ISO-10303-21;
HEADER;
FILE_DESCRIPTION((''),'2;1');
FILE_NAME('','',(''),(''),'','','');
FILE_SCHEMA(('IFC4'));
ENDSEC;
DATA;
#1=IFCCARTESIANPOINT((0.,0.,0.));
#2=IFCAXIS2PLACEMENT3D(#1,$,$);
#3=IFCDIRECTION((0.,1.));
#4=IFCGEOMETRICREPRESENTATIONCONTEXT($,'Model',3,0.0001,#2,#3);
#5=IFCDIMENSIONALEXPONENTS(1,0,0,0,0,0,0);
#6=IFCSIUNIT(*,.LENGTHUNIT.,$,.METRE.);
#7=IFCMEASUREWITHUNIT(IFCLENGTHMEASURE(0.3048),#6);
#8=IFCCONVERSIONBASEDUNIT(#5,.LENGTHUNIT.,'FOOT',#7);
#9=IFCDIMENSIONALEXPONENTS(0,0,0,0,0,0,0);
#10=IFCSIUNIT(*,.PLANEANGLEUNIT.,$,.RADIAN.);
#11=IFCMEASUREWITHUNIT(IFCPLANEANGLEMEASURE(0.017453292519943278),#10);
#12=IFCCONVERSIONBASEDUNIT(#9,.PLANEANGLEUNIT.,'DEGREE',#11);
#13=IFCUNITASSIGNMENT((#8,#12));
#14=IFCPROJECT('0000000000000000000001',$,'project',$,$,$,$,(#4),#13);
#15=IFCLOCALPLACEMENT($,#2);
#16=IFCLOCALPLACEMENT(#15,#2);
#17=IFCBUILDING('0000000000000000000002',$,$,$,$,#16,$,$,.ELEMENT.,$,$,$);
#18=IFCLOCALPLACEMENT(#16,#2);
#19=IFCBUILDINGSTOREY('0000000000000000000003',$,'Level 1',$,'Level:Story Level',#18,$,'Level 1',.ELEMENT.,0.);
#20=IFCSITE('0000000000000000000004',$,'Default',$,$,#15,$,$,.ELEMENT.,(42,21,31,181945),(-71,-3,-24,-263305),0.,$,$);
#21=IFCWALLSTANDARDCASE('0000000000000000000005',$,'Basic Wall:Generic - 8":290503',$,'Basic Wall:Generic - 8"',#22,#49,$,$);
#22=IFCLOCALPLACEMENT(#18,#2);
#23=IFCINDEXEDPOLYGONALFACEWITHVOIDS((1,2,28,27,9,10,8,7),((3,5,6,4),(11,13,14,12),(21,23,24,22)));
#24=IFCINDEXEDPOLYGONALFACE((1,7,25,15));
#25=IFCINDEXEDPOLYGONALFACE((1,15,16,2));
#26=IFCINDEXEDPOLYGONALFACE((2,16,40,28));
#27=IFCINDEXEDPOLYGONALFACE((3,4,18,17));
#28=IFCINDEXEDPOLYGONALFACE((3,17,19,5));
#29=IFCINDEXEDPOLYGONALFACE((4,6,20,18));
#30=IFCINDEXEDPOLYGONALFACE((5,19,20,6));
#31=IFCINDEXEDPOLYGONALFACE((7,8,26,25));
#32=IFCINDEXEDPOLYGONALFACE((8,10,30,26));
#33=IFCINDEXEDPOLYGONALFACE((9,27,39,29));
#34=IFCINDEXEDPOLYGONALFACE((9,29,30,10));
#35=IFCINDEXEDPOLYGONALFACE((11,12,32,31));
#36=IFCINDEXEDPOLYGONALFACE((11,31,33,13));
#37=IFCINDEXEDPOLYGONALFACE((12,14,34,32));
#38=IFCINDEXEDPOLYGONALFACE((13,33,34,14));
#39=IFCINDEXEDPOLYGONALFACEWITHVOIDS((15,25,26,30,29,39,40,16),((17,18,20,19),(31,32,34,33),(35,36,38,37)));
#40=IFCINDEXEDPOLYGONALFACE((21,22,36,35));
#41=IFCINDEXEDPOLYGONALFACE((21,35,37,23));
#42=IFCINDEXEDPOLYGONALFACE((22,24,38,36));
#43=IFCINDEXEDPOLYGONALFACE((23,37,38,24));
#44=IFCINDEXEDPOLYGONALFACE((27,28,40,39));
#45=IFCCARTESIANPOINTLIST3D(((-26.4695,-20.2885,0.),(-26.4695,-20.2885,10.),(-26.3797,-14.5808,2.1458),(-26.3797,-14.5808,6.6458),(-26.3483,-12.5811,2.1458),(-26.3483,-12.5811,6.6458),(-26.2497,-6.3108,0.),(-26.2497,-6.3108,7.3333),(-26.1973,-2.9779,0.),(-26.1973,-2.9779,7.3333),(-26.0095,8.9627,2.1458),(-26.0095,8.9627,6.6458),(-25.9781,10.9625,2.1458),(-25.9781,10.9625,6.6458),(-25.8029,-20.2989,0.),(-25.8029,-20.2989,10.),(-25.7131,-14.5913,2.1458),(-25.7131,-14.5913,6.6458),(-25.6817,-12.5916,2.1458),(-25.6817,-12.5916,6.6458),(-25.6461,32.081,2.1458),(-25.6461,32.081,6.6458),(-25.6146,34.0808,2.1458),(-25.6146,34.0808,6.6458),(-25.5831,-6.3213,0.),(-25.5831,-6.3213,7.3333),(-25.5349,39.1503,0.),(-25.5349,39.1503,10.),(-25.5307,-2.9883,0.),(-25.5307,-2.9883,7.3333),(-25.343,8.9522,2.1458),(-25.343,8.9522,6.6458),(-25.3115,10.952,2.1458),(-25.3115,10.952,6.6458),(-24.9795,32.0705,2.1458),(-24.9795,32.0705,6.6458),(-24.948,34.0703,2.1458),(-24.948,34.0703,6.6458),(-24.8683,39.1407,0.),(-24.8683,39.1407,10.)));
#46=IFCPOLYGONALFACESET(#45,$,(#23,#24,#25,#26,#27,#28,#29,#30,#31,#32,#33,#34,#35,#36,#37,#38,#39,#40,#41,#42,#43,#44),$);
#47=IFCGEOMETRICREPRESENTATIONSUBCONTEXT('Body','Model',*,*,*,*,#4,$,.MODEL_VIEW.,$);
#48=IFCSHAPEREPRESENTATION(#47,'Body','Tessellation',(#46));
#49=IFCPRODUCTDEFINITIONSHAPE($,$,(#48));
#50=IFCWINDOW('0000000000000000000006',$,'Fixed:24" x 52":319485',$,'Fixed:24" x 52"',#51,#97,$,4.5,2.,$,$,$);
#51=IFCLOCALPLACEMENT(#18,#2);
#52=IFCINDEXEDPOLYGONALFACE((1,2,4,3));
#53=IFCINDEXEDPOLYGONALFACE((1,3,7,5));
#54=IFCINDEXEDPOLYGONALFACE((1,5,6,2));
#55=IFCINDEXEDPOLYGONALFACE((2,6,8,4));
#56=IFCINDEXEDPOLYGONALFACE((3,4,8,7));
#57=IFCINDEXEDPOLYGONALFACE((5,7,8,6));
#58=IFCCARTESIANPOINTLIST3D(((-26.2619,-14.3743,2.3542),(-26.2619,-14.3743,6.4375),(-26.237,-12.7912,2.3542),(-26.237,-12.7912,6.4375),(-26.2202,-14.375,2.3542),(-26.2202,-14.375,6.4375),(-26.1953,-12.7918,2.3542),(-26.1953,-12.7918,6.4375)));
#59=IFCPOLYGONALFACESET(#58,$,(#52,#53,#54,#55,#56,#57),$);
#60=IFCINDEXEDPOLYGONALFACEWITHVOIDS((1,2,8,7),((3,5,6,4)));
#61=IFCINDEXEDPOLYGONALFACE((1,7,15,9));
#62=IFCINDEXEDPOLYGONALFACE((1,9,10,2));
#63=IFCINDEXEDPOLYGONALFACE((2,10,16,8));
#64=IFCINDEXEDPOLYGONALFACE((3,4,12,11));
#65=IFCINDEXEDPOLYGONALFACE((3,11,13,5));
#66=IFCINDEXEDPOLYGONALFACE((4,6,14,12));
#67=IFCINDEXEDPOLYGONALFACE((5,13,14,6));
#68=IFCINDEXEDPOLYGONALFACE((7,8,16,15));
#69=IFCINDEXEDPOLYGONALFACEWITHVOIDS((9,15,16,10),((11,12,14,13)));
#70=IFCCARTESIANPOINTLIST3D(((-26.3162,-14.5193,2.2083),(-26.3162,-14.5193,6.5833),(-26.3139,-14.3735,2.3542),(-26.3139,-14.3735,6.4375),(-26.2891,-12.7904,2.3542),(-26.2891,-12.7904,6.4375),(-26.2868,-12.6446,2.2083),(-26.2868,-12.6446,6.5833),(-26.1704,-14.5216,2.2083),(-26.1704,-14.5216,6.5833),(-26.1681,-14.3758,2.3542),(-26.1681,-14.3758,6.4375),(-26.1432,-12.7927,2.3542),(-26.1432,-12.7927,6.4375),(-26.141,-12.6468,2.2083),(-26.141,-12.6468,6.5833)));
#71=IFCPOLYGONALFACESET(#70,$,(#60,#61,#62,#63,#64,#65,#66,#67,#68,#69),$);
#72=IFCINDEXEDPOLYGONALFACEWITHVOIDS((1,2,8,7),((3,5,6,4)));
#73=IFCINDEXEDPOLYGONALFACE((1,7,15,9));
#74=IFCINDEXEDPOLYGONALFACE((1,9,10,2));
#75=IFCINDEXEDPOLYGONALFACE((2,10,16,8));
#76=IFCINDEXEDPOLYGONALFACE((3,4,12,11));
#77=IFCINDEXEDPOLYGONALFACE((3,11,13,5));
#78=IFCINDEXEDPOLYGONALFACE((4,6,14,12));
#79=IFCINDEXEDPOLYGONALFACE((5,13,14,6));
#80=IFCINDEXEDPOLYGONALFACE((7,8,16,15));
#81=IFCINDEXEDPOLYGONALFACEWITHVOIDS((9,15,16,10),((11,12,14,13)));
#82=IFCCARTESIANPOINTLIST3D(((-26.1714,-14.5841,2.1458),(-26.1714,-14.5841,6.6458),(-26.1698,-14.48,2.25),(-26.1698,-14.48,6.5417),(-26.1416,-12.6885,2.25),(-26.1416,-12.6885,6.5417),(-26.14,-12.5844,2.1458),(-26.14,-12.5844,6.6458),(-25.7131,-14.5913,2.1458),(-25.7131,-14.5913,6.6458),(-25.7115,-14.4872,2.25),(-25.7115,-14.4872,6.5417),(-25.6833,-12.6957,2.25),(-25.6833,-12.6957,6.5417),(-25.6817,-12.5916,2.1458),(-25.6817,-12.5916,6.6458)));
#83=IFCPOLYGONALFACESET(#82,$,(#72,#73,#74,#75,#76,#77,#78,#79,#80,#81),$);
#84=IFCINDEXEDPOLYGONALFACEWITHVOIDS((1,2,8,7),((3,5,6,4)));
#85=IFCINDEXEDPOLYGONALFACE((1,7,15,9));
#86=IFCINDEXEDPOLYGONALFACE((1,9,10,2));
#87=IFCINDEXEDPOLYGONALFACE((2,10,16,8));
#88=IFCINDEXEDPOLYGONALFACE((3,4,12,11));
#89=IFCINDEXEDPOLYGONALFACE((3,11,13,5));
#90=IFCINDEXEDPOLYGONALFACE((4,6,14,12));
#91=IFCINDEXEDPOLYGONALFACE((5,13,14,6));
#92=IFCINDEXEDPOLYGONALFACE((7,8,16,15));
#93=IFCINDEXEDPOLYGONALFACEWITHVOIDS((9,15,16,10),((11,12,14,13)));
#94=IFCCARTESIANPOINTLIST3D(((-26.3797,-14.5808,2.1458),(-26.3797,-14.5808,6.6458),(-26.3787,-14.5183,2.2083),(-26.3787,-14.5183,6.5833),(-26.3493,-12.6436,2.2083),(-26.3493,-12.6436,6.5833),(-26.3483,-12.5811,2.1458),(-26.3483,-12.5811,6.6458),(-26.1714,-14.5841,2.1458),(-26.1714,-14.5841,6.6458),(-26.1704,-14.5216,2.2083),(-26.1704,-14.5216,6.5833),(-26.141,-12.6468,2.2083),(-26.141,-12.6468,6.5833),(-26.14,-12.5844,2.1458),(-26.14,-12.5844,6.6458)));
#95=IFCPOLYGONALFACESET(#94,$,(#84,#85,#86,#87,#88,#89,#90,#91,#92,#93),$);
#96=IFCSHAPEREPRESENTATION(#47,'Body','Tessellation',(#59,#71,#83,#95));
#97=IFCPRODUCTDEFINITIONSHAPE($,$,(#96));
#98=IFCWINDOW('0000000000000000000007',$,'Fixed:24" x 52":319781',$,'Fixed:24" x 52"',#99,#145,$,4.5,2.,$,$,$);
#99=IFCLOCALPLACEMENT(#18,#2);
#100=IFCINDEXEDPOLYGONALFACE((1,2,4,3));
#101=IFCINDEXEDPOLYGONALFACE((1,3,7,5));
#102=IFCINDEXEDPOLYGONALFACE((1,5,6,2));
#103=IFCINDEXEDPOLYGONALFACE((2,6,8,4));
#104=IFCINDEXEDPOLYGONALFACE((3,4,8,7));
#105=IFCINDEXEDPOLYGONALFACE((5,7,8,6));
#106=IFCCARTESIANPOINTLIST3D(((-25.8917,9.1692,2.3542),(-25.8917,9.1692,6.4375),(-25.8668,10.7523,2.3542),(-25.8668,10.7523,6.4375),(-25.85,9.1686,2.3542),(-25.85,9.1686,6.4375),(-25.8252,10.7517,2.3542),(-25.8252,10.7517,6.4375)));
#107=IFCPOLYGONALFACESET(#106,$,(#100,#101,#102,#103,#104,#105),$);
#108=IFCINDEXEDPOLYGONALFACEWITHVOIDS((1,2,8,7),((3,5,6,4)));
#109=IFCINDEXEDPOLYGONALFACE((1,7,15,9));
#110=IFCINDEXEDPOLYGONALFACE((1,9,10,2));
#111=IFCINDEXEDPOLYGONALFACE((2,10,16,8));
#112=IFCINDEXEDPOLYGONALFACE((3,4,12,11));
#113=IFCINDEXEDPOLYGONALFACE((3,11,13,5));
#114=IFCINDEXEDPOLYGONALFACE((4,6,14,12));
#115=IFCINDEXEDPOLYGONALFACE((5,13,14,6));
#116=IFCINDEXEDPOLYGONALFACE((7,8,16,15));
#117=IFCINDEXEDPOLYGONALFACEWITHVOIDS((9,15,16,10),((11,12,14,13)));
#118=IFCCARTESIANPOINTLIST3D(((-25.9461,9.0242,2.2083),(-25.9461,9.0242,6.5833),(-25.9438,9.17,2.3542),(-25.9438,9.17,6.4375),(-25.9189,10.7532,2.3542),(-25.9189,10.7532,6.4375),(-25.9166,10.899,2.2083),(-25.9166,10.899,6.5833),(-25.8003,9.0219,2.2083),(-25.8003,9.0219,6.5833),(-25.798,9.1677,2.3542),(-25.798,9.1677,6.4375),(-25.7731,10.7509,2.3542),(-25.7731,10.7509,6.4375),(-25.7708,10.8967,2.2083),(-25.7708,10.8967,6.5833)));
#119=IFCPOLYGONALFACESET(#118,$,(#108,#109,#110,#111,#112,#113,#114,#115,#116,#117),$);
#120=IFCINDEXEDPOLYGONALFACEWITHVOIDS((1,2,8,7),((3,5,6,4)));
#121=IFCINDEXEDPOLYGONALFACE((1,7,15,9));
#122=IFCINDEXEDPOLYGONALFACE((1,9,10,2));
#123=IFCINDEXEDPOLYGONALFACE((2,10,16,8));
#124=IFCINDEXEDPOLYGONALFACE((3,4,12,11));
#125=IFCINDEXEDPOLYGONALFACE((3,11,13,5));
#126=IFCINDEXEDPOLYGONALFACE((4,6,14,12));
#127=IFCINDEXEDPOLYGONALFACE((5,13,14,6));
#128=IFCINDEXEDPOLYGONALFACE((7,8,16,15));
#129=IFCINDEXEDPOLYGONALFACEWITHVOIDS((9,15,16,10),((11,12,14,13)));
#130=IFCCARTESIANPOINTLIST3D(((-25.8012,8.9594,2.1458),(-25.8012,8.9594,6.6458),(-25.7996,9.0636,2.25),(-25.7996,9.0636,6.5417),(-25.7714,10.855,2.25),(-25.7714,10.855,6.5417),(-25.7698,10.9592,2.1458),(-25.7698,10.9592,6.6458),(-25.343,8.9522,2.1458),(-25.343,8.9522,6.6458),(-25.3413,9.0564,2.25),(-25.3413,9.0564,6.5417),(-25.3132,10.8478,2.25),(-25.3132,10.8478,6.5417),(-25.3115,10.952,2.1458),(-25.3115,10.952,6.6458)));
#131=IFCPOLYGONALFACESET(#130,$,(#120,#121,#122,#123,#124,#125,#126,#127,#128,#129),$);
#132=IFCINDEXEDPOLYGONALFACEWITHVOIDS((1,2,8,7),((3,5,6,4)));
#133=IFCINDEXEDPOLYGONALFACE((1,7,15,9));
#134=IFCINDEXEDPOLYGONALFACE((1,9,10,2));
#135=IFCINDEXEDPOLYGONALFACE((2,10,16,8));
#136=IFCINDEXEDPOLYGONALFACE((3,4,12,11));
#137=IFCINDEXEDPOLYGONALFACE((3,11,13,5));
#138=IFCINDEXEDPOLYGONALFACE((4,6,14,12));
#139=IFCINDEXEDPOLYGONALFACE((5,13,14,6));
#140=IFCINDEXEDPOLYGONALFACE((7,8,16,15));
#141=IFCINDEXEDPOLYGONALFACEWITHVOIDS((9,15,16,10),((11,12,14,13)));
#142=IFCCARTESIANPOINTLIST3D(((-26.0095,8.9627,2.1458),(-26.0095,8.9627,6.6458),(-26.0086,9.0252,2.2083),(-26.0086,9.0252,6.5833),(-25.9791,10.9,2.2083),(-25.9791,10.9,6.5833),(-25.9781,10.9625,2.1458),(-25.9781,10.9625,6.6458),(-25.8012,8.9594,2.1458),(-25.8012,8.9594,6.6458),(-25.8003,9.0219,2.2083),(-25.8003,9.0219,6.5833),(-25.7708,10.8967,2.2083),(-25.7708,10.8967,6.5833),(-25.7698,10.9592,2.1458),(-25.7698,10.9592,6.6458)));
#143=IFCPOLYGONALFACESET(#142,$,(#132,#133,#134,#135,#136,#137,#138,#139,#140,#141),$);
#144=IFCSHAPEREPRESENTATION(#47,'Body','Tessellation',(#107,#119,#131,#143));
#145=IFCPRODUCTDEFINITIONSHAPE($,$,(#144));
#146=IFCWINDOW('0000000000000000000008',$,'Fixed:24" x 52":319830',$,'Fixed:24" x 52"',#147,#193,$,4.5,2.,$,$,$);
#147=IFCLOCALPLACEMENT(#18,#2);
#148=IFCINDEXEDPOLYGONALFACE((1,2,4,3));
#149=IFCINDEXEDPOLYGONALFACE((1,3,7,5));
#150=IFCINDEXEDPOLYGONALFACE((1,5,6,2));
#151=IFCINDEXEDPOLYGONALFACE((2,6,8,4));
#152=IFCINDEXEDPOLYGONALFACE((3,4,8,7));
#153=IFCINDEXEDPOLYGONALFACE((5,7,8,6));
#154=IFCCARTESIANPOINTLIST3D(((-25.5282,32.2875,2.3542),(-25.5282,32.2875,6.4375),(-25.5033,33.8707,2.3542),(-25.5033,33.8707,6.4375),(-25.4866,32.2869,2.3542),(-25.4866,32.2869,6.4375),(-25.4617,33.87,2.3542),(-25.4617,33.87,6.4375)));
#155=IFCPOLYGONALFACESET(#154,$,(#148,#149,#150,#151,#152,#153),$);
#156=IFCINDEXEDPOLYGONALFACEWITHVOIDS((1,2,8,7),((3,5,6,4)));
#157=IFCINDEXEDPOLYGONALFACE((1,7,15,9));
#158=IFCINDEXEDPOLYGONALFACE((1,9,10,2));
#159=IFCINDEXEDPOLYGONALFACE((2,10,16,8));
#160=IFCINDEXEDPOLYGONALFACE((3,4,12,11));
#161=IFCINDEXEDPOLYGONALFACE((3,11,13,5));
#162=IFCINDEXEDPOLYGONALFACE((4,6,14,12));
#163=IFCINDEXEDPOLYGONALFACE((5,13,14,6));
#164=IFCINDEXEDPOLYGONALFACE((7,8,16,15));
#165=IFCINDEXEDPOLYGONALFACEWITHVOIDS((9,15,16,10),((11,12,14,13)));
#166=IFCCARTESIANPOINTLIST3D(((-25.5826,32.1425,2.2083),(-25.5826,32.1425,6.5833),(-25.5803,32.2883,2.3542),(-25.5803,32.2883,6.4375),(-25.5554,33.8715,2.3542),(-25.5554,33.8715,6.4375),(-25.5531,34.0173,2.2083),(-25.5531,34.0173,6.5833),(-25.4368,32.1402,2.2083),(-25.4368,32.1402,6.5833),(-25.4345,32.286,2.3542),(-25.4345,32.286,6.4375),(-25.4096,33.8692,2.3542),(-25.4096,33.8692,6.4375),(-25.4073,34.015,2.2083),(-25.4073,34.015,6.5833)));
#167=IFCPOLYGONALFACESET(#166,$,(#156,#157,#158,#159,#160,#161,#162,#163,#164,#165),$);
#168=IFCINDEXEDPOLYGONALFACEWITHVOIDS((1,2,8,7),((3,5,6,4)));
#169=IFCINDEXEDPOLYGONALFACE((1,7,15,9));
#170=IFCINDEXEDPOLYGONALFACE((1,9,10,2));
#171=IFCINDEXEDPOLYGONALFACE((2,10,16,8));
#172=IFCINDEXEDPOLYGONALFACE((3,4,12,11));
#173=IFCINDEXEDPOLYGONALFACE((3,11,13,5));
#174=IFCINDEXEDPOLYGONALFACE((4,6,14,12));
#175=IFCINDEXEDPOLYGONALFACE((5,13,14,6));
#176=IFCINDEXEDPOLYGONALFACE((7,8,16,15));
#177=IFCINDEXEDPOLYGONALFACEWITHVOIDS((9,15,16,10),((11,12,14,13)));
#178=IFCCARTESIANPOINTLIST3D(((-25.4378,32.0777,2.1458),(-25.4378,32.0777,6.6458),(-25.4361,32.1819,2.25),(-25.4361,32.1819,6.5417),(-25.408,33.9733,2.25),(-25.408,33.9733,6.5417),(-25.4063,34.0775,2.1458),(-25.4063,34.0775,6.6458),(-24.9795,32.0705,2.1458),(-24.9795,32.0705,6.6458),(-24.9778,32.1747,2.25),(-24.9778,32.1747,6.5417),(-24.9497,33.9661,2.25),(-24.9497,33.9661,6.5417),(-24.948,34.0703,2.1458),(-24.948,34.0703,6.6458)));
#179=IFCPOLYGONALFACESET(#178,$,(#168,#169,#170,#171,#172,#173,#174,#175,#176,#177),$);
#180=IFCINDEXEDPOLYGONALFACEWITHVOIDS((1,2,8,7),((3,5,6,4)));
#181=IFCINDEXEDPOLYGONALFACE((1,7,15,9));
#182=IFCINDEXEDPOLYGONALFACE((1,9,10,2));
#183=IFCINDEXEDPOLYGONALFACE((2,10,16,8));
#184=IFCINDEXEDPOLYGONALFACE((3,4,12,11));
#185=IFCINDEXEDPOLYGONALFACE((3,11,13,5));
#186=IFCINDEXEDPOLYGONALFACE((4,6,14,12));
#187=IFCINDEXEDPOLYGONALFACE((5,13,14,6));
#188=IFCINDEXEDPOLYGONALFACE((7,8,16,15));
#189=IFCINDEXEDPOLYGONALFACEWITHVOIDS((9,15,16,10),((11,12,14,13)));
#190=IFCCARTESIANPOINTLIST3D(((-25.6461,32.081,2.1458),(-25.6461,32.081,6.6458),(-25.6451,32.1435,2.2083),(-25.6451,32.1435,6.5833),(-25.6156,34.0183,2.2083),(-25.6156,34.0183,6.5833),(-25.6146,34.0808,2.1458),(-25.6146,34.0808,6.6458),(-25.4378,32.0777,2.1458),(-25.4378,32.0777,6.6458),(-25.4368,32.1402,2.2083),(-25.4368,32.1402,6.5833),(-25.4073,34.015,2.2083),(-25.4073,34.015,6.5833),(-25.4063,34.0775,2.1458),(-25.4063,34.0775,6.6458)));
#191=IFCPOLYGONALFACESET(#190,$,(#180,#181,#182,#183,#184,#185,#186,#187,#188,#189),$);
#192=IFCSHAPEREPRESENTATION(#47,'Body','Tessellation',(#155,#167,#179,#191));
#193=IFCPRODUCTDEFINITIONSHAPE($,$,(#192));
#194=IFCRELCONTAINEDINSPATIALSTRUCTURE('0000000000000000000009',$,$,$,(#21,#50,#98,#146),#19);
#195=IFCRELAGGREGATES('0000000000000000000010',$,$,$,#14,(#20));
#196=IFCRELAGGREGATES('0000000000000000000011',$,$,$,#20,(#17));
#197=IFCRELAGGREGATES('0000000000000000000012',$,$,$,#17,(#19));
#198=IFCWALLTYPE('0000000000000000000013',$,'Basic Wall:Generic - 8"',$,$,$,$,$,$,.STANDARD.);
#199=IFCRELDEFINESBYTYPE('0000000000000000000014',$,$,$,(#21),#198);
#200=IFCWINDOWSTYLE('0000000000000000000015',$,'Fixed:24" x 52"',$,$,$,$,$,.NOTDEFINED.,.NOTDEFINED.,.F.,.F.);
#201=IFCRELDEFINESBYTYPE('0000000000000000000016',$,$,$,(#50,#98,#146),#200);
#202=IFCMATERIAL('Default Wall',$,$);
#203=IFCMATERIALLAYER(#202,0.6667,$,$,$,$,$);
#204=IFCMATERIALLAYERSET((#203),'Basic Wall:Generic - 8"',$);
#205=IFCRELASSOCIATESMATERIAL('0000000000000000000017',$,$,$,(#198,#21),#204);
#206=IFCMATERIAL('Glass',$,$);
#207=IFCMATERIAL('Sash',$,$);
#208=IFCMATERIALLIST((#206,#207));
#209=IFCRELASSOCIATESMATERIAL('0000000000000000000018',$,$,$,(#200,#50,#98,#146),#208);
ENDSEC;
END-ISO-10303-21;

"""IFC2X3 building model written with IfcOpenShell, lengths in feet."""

from ifc_helpers import new_model, entity, si_unit, converted_unit, direction, frame, frame_2d, origin, place, context, subcontext, project, spatial, polyline, rectangle, outline, extrude, source, transform, mapped, material, material_list, layer, layer_set, layer_usage, type_object, type_shapes, element, fill, save


model = new_model("IFC2X3")

# Units and contexts
model_context = context("Model", 3, precision=0.0001, world=origin(), true_north=direction((0.0, 1.0)))
body_context = subcontext(model_context, "Body", "Model", "MODEL_VIEW")
ifc_project = project(units=[converted_unit("LENGTHUNIT", "FOOT", entity("IfcLengthMeasure", 0.3048), si_unit("LENGTHUNIT", "METRE"), dimensions=[1, 0, 0, 0, 0, 0, 0]), converted_unit("PLANEANGLEUNIT", "DEGREE", entity("IfcPlaneAngleMeasure", 0.017453292519943278), si_unit("PLANEANGLEUNIT", "RADIAN"), dimensions=[0, 0, 0, 0, 0, 0, 0])], contexts=[model_context])

# Site, building, storey
site_placement = place(None, origin())
site = spatial("IfcSite", under=ifc_project, at=site_placement, Name="Default", CompositionType="ELEMENT", RefLatitude=(42, 21, 31, 181945), RefLongitude=(-71, -3, -24, -263305), RefElevation=0.0)
building_placement = place(site_placement, origin())
building = spatial("IfcBuilding", under=site, at=building_placement, CompositionType="ELEMENT")
storey_placement = place(building_placement, origin())
storey = spatial("IfcBuildingStorey", under=building, at=storey_placement, Name="Level 1", ObjectType="Level:Story Level", LongName="Level 1", CompositionType="ELEMENT", Elevation=0.0)

# Wall, openings, windows
ifc_material_1 = material(Name="Default Wall")
ifc_layer_1 = layer(ifc_material_1, 0.6667)
ifc_layer_set_1 = layer_set([ifc_layer_1], Name="Basic Wall:Generic - 8\"")
ifc_layer_usage_1 = layer_usage(ifc_layer_set_1, "AXIS2", "NEGATIVE", 0.3333)
wall_type_1 = type_object("IfcWallType", Name="Basic Wall:Generic - 8\"", PredefinedType="STANDARD", material=ifc_layer_set_1)
wall_1_placement = place(storey_placement, frame((-25.2016, 39.146, 0.0), z_axis=(0.0, 0.0, 1.0), x_axis=(-0.015721, -0.999876, 0.0)))
wall_1 = element("IfcWallStandardCase", 1, at=wall_1_placement, inside=storey, type_object=wall_type_1, material=ifc_layer_usage_1, Name="Basic Wall:Generic - 8\":290503", ObjectType="Basic Wall:Generic - 8\"", context=body_context, shape_type="SweptSolid", body=[
    extrude(outline(polyline([(0.001, -0.3333), (59.447, -0.3333), (59.447, 0.3333), (58.7804, 0.3333), (0.0, 0.3333), (0.001, -0.3333)])), origin(), (0.0, 0.0, 1.0), 10.0),
])
opening_1_placement = place(wall_1_placement, frame((45.4676, 0.3333, 0.0)))
element("IfcOpeningElement", 2, at=opening_1_placement, cuts=wall_1, ObjectType="Opening", context=body_context, shape_type="SweptSolid", body=[
    extrude(rectangle(XDim=7.3333, YDim=3.3333, at=frame_2d((3.6667, 1.6667), x_axis=(1.0, 0.0))), frame((0.0, 0.0, 0.0), z_axis=(0.0, -1.0, 0.0), x_axis=(0.0, 0.0, 1.0)), (0.0, 0.0, 1.0), 0.6667),
])
opening_2_placement = place(wall_1_placement, frame((53.7387, 0.3333, 2.1458)))
opening_2 = element("IfcOpeningElement", 3, at=opening_2_placement, cuts=wall_1, ObjectType="Opening", context=body_context, shape_type="SweptSolid", body=[
    extrude(rectangle(XDim=4.5, YDim=2.0, at=frame_2d((2.25, 1.0), x_axis=(-1.0, 0.0))), frame((0.0, 0.0, 0.0), z_axis=(0.0, -1.0, 0.0), x_axis=(0.0, 0.0, 1.0)), (0.0, 0.0, 1.0), 0.6667),
])
opening_3_placement = place(wall_1_placement, frame((30.1922, 0.3333, 2.1458)))
opening_3 = element("IfcOpeningElement", 4, at=opening_3_placement, cuts=wall_1, ObjectType="Opening", context=body_context, shape_type="SweptSolid", body=[
    extrude(rectangle(XDim=4.5, YDim=2.0, at=frame_2d((2.25, 1.0), x_axis=(-1.0, 0.0))), frame((0.0, 0.0, 0.0), z_axis=(0.0, -1.0, 0.0), x_axis=(0.0, 0.0, 1.0)), (0.0, 0.0, 1.0), 0.6667),
])
opening_4_placement = place(wall_1_placement, frame((7.0711, 0.3333, 2.1458)))
opening_4 = element("IfcOpeningElement", 5, at=opening_4_placement, cuts=wall_1, ObjectType="Opening", context=body_context, shape_type="SweptSolid", body=[
    extrude(rectangle(XDim=4.5, YDim=2.0, at=frame_2d((2.25, 1.0), x_axis=(-1.0, 0.0))), frame((0.0, 0.0, 0.0), z_axis=(0.0, -1.0, 0.0), x_axis=(0.0, 0.0, 1.0)), (0.0, 0.0, 1.0), 0.6667),
])
ifc_material_2 = material(Name="Glass")
ifc_material_3 = material(Name="Sash")
ifc_material_list_1 = material_list([ifc_material_2, ifc_material_3])
window_style = type_object("IfcWindowStyle", Name="Fixed:24\" x 52\"", ConstructionType="NOTDEFINED", OperationType="NOTDEFINED", ParameterTakesPrecedence=False, Sizeable=False, material=ifc_material_list_1)
shared_shape_1 = source(origin(), body_context, "Body", "SweptSolid", [
    extrude(rectangle(XDim=0.0417, YDim=1.5833, at=frame_2d((0.0, 0.0), x_axis=(1.0, 0.0))), frame((1.0, 0.5312, 0.2083), z_axis=(0.0, 0.0, 1.0), x_axis=(0.0, 1.0, 0.0)), (0.0, 0.0, 1.0), 4.0833),
    extrude(outline(polyline([(-0.9375, -2.1875), (0.9375, -2.1875), (0.9375, 2.1875), (-0.9375, 2.1875), (-0.9375, -2.1875)]), holes=[polyline([(-0.7917, -2.0417), (-0.7917, 2.0417), (0.7917, 2.0417), (0.7917, -2.0417), (-0.7917, -2.0417)])]), frame((1.0, 0.4583, 2.25), z_axis=(0.0, 1.0, 0.0), x_axis=(1.0, 0.0, 0.0)), (0.0, 0.0, 1.0), 0.1458),
    extrude(outline(polyline([(-1.0, -2.25), (1.0, -2.25), (1.0, 2.25), (-1.0, 2.25), (-1.0, -2.25)]), holes=[polyline([(-0.8958, -2.1458), (-0.8958, 2.1458), (0.8958, 2.1458), (0.8958, -2.1458), (-0.8958, -2.1458)])]), frame((1.0, 0.0, 2.25), z_axis=(0.0, 1.0, 0.0), x_axis=(1.0, 0.0, 0.0)), (0.0, 0.0, 1.0), 0.4583),
    extrude(outline(polyline([(-2.25, -1.0), (2.25, -1.0), (2.25, 1.0), (-2.25, 1.0), (-2.25, -1.0)]), holes=[polyline([(-2.1875, -0.9375), (-2.1875, 0.9375), (2.1875, 0.9375), (2.1875, -0.9375), (-2.1875, -0.9375)])]), frame((1.0, 0.4583, 2.25), z_axis=(0.0, 1.0, 0.0), x_axis=(0.0, 0.0, -1.0)), (0.0, 0.0, 1.0), 0.2083),
])
type_shapes(window_style, [shared_shape_1])
window_1_placement = place(opening_2_placement, frame((0.0, 0.0, 0.0), z_axis=(0.0, 0.0, 1.0), x_axis=(-1.0, 0.0, 0.0)))
window_1 = element("IfcWindow", 6, at=window_1_placement, inside=storey, type_object=window_style, material=ifc_material_list_1, Name="Fixed:24\" x 52\":319485", ObjectType="Fixed:24\" x 52\"", OverallHeight=4.5, OverallWidth=2.0, context=body_context, shape_type="MappedRepresentation", body=[
    mapped(shared_shape_1, transform((0.0, 0.0, 0.0), scale=1.0)),
])
fill(opening_2, window_1)
window_2_placement = place(opening_3_placement, frame((0.0, 0.0, 0.0), z_axis=(0.0, 0.0, 1.0), x_axis=(-1.0, 0.0, 0.0)))
window_2 = element("IfcWindow", 7, at=window_2_placement, inside=storey, type_object=window_style, material=ifc_material_list_1, Name="Fixed:24\" x 52\":319781", ObjectType="Fixed:24\" x 52\"", OverallHeight=4.5, OverallWidth=2.0, context=body_context, shape_type="MappedRepresentation", body=[
    mapped(shared_shape_1, transform((0.0, 0.0, 0.0), scale=1.0)),
])
fill(opening_3, window_2)
window_3_placement = place(opening_4_placement, frame((0.0, 0.0, 0.0), z_axis=(0.0, 0.0, 1.0), x_axis=(-1.0, 0.0, 0.0)))
window_3 = element("IfcWindow", 8, at=window_3_placement, inside=storey, type_object=window_style, material=ifc_material_list_1, Name="Fixed:24\" x 52\":319830", ObjectType="Fixed:24\" x 52\"", OverallHeight=4.5, OverallWidth=2.0, context=body_context, shape_type="MappedRepresentation", body=[
    mapped(shared_shape_1, transform((0.0, 0.0, 0.0), scale=1.0)),
])
fill(opening_4, window_3)

save(model, "model.ifc")
